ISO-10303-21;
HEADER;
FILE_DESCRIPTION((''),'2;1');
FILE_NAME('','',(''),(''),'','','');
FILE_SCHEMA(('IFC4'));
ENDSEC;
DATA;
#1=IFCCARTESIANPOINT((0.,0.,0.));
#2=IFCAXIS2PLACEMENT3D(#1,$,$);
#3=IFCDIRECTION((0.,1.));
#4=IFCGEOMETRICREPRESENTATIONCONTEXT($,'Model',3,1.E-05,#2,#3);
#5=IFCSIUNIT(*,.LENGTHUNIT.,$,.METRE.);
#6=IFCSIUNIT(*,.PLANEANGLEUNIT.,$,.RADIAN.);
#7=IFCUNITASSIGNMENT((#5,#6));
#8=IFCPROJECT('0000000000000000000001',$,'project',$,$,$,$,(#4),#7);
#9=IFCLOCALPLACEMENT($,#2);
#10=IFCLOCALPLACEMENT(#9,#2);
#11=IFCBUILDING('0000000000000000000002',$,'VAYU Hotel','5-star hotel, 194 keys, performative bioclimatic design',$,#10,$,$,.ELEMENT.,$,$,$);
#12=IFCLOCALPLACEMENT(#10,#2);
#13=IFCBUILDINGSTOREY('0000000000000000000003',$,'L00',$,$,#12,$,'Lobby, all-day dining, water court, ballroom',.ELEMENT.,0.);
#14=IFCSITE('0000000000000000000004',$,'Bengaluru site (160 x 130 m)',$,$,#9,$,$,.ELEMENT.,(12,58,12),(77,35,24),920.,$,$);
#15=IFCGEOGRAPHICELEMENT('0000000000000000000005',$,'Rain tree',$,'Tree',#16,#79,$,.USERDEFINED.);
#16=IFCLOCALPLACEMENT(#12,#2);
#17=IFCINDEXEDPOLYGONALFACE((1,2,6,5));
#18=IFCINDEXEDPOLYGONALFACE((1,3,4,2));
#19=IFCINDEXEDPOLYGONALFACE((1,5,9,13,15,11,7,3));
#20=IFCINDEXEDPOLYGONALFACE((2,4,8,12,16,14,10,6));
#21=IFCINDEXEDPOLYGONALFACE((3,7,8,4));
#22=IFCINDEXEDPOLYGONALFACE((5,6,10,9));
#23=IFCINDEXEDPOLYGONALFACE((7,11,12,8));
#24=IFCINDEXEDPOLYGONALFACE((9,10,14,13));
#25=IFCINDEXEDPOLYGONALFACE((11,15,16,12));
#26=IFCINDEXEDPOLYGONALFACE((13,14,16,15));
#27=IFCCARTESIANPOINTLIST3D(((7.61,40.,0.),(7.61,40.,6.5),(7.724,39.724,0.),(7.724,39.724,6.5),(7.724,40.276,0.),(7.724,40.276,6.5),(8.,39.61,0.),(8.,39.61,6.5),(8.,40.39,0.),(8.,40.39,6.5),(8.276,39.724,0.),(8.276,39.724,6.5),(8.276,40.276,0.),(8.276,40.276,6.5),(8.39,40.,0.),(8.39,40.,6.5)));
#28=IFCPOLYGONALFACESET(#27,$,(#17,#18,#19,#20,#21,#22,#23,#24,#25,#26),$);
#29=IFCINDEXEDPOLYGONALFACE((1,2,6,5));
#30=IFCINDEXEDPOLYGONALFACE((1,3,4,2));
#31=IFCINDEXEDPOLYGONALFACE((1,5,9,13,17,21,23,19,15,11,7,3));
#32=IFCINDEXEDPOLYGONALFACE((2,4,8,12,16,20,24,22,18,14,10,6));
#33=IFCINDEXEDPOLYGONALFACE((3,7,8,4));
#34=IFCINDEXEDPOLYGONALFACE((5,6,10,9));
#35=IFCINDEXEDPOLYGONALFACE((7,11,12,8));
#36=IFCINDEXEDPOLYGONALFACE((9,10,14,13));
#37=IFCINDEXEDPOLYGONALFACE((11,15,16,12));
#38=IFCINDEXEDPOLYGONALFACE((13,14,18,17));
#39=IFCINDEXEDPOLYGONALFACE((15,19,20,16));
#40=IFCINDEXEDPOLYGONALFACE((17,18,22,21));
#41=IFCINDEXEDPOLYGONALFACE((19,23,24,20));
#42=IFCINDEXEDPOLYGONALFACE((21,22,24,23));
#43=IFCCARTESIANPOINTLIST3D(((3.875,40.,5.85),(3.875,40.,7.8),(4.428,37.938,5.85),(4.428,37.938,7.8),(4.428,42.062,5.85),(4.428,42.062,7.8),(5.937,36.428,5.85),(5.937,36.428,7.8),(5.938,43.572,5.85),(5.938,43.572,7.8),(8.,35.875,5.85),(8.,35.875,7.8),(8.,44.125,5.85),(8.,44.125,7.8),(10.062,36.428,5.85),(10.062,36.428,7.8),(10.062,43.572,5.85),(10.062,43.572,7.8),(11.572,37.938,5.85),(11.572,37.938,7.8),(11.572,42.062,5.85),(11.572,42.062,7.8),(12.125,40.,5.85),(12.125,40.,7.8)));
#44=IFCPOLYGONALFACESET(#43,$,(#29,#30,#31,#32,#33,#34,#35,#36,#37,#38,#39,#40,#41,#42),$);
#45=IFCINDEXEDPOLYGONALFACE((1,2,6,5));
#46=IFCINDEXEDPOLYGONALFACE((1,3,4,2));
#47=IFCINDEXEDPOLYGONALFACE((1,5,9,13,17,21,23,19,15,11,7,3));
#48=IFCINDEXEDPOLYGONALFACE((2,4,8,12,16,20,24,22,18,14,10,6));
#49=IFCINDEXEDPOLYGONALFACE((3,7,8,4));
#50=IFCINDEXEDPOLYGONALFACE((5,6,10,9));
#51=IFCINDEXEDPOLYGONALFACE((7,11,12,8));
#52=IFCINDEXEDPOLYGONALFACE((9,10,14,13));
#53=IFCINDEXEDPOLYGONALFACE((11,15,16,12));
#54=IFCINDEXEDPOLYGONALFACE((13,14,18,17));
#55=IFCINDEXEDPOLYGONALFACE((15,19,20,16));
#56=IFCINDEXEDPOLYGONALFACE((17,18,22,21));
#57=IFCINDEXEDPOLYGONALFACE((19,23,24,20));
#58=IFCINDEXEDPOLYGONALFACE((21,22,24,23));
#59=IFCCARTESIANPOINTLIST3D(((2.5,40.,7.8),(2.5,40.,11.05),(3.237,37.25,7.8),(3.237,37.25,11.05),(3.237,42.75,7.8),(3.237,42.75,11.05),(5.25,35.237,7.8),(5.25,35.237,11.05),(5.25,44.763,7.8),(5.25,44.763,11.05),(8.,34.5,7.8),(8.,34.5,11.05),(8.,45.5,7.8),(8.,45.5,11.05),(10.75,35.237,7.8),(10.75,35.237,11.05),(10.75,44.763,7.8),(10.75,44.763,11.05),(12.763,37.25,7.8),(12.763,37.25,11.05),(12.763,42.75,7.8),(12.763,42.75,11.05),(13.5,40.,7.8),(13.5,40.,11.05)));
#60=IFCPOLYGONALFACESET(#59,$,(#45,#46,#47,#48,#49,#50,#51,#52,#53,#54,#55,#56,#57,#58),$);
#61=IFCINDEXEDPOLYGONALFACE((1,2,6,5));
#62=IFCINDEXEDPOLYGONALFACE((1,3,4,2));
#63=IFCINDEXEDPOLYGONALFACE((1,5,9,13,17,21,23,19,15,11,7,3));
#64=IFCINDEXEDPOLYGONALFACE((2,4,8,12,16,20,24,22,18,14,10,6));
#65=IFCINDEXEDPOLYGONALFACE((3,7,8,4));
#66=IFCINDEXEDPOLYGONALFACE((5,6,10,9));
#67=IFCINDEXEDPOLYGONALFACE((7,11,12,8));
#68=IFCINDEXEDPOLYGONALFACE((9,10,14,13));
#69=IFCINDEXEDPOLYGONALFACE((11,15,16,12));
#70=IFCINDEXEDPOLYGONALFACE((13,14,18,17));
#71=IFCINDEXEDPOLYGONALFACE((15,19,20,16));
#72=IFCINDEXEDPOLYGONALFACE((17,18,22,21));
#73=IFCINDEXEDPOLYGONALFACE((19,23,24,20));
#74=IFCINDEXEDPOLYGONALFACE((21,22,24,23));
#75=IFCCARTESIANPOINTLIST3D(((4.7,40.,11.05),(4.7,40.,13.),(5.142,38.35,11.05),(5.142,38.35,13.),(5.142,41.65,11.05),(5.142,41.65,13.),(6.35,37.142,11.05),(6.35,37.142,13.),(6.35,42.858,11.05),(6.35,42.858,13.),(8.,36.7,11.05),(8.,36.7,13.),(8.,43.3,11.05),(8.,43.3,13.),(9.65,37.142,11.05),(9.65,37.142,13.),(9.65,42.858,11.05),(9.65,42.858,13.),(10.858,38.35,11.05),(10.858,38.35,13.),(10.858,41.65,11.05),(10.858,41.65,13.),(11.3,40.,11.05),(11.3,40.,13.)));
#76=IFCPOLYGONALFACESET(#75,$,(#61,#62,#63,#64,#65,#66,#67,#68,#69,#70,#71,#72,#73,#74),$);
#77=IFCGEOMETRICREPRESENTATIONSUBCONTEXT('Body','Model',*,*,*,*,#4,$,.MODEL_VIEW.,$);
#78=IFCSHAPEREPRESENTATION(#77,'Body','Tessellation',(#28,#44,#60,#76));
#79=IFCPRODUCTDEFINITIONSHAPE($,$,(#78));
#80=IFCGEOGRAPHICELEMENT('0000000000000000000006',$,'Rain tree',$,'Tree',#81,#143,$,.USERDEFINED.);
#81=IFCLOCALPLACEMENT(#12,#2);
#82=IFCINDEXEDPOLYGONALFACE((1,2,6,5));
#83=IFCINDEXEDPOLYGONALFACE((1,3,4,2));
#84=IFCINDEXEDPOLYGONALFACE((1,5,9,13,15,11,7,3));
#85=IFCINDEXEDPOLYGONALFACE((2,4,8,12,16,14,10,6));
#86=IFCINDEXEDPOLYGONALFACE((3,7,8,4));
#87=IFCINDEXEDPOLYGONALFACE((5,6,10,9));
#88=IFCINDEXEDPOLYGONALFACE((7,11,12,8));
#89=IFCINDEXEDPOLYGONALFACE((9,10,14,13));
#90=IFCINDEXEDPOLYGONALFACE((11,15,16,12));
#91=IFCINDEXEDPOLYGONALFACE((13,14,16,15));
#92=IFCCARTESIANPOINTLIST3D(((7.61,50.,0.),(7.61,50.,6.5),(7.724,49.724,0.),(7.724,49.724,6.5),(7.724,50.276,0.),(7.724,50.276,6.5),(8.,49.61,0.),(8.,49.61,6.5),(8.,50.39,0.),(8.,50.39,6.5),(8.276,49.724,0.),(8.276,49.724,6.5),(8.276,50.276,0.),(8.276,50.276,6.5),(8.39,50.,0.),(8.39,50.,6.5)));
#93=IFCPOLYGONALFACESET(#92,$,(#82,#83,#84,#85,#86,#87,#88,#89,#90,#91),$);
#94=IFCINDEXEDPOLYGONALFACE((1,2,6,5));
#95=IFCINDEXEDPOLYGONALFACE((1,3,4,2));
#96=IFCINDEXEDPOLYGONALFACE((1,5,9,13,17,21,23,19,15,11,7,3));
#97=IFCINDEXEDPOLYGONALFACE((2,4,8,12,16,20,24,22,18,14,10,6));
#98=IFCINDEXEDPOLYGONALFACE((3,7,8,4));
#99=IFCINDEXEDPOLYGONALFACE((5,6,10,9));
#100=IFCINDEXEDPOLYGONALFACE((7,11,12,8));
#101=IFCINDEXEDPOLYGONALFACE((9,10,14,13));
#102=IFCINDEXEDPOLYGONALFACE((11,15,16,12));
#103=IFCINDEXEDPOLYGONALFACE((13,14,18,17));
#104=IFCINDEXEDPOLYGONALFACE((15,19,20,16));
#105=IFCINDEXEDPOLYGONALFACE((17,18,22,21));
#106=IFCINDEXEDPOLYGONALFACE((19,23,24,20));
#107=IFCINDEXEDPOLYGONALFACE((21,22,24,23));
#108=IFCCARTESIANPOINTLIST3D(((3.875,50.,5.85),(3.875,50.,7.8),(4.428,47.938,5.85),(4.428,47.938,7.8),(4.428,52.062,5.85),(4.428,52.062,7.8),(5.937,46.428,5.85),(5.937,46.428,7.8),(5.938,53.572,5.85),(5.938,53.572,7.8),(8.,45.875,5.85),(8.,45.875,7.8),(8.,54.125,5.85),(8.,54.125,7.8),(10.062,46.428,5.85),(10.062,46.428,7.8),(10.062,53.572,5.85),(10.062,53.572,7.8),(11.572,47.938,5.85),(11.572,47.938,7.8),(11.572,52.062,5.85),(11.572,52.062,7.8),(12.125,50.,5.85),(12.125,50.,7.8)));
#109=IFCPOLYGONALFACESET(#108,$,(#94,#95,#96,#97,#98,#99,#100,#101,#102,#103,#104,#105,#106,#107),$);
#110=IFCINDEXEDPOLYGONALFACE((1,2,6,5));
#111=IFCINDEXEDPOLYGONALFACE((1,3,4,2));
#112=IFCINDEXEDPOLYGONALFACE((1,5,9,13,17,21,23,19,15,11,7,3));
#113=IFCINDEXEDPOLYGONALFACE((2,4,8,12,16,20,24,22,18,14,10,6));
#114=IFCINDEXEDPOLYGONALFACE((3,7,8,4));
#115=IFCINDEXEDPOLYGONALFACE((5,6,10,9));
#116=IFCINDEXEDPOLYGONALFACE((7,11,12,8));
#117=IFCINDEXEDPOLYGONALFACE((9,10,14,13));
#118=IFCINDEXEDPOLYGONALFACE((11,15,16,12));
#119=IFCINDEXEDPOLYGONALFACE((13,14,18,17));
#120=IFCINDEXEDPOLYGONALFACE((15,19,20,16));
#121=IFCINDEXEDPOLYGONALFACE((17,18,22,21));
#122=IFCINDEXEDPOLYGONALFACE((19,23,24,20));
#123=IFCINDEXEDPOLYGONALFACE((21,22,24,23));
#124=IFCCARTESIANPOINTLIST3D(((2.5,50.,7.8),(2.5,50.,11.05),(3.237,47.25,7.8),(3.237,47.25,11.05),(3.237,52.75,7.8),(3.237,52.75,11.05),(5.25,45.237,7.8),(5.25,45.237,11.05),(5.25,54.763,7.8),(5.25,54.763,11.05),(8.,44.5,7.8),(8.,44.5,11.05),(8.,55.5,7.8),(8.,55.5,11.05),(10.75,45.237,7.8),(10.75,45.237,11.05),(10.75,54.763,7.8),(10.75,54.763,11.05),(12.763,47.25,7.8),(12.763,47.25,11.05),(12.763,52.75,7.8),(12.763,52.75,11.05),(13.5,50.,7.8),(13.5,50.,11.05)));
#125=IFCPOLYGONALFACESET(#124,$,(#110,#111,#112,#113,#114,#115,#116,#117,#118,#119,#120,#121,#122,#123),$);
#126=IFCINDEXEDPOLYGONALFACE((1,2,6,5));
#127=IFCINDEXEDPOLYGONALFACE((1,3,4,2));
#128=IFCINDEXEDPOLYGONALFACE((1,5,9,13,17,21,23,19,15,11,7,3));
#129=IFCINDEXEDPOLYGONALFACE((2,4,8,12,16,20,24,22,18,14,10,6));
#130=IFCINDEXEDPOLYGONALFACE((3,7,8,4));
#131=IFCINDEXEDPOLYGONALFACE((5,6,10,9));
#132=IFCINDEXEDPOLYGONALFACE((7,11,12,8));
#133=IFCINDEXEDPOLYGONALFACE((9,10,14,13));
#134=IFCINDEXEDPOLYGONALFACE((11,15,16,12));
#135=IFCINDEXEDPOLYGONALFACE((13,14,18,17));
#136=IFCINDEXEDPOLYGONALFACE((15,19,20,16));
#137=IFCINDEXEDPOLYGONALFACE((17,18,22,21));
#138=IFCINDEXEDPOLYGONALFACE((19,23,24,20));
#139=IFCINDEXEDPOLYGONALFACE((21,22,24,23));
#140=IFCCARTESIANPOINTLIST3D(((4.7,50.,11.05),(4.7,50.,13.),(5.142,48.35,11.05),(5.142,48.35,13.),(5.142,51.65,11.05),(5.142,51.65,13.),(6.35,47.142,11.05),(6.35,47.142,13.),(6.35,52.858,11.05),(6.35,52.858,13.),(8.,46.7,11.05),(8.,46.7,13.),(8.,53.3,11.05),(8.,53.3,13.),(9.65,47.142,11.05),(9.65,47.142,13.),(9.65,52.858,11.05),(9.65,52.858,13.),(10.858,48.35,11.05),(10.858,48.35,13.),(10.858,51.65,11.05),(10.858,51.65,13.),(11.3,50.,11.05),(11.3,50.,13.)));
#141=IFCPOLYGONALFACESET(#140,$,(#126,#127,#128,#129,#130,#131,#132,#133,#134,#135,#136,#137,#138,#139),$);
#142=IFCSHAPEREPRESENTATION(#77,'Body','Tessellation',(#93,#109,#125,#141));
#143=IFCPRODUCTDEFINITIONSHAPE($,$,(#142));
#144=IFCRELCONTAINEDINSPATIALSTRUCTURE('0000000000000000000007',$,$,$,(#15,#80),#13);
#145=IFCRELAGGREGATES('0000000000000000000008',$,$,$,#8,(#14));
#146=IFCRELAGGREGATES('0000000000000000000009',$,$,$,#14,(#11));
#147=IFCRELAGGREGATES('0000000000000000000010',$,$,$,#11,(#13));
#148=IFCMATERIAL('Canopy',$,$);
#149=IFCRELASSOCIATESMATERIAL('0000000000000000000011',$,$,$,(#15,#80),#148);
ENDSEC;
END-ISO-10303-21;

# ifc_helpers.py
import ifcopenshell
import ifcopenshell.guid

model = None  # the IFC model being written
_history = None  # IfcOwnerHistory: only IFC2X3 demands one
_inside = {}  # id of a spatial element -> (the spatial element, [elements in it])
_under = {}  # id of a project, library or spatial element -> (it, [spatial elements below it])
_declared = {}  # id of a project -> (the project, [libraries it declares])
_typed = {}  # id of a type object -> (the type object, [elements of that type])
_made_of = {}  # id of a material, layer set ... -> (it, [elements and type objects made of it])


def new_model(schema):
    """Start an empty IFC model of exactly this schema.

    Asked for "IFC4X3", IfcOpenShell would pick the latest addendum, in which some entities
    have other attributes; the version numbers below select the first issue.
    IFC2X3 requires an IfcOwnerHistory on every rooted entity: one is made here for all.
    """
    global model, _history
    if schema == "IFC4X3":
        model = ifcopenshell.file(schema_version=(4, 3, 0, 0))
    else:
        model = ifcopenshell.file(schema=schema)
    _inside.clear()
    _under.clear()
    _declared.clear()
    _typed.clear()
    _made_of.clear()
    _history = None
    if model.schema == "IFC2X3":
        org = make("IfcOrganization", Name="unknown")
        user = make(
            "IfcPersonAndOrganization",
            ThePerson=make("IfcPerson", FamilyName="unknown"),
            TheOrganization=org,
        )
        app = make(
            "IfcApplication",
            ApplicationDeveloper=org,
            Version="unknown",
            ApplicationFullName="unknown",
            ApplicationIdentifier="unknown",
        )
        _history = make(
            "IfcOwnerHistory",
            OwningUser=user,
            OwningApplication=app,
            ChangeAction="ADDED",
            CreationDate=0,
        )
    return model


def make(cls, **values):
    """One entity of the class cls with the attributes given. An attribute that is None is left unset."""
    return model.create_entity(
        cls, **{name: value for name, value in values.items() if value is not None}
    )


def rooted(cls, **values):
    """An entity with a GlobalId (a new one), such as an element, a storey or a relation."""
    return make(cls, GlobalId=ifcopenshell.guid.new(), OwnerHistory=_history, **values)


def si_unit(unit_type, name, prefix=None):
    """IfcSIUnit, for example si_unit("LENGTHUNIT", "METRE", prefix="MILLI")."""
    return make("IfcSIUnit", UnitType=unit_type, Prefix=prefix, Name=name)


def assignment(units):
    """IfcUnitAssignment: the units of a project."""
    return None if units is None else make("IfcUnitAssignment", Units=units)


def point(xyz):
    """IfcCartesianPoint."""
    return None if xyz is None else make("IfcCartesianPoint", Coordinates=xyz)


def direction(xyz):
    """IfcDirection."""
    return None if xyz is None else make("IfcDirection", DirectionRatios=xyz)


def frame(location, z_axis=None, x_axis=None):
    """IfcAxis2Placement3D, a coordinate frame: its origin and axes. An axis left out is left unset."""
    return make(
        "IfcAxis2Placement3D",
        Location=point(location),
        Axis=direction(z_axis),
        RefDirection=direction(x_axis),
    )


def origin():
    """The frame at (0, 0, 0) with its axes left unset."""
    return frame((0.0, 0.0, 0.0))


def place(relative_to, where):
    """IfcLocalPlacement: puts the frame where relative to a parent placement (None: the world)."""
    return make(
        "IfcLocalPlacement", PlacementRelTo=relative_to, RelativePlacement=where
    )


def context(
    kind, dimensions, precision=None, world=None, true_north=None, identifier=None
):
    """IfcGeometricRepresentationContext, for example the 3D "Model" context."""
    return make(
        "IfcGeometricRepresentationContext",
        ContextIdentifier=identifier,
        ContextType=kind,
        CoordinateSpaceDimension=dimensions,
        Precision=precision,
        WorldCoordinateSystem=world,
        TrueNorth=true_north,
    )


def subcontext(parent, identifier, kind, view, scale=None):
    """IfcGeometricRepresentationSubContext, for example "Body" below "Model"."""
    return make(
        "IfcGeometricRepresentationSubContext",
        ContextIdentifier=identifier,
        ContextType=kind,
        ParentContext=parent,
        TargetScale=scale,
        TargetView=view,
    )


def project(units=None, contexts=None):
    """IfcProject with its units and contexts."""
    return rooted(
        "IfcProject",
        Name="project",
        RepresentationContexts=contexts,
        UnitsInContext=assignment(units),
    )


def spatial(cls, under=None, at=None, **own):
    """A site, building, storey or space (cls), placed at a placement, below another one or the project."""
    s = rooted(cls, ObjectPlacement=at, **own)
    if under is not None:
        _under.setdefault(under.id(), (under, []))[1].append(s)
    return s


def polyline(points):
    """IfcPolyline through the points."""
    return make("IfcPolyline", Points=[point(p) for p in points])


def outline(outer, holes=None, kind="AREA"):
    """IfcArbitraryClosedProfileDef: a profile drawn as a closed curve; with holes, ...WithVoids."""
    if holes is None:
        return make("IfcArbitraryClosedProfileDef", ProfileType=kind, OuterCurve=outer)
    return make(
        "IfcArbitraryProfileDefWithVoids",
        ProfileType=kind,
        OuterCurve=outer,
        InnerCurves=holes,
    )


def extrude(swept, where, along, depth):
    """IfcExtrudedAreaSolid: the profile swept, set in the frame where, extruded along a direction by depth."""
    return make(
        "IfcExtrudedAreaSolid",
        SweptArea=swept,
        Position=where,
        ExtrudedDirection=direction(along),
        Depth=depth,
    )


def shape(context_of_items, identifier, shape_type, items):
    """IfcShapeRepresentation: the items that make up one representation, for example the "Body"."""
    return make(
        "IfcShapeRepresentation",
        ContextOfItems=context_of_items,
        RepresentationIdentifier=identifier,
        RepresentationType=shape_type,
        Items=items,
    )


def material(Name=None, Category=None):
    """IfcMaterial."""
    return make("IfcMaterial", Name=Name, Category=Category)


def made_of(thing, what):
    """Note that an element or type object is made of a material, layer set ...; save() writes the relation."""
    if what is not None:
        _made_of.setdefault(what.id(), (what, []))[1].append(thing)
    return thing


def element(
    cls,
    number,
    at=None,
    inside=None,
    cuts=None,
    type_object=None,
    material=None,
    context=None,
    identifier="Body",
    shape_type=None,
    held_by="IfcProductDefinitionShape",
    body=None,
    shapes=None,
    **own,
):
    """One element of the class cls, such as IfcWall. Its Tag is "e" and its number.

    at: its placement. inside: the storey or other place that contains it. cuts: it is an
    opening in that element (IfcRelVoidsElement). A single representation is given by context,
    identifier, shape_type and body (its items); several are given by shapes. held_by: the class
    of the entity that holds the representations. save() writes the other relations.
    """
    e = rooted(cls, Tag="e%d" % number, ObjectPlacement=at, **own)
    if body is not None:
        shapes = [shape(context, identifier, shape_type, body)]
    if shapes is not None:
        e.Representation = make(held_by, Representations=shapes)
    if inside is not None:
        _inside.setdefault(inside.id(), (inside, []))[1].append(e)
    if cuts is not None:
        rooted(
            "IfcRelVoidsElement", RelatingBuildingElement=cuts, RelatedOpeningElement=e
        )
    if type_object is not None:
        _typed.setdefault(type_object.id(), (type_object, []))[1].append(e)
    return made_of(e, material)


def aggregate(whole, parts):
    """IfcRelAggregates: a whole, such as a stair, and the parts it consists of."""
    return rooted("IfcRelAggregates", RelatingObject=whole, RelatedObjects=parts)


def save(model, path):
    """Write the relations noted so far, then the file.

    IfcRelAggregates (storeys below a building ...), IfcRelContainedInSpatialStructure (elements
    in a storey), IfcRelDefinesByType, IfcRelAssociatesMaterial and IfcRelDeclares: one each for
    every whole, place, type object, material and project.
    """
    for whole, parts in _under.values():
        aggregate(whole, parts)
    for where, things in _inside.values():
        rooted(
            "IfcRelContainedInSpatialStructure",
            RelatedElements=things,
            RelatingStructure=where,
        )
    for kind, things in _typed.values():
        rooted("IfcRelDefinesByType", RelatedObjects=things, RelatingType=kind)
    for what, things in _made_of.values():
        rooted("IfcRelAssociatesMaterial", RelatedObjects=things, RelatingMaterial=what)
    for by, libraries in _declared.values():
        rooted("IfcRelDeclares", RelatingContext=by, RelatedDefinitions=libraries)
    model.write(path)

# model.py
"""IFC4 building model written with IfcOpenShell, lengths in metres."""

from ifc_helpers import new_model, si_unit, direction, frame, origin, place, context, subcontext, project, spatial, polyline, outline, extrude, material, element, save


model = new_model("IFC4")

# Units and contexts
model_context = context("Model", 3, precision=1e-05, world=origin(), true_north=direction((0.0, 1.0)))
body_context = subcontext(model_context, "Body", "Model", "MODEL_VIEW")
ifc_project = project(units=[si_unit("LENGTHUNIT", "METRE"), si_unit("PLANEANGLEUNIT", "RADIAN")], contexts=[model_context])

# Site, building, storey
site_placement = place(None, origin())
site = spatial("IfcSite", under=ifc_project, at=site_placement, Name="Bengaluru site (160 x 130 m)", CompositionType="ELEMENT", RefLatitude=(12, 58, 12), RefLongitude=(77, 35, 24), RefElevation=920.0)
building_placement = place(site_placement, origin())
building = spatial("IfcBuilding", under=site, at=building_placement, Name="VAYU Hotel", Description="5-star hotel, 194 keys, performative bioclimatic design", CompositionType="ELEMENT")
storey_placement = place(building_placement, origin())
storey = spatial("IfcBuildingStorey", under=building, at=storey_placement, Name="L00", LongName="Lobby, all-day dining, water court, ballroom", CompositionType="ELEMENT", Elevation=0.0)

# Geographic elements
ifc_material_1 = material(Name="Canopy")
geographic_element_1_placement = place(storey_placement, origin())
element("IfcGeographicElement", 1, at=geographic_element_1_placement, inside=storey, material=ifc_material_1, Name="Rain tree", ObjectType="Tree", PredefinedType="USERDEFINED", context=body_context, shape_type="SweptSolid", body=[
    extrude(outline(polyline([(8.39, 40.0), (8.276, 40.276), (8.0, 40.39), (7.724, 40.276), (7.61, 40.0), (7.724, 39.724), (8.0, 39.61), (8.276, 39.724), (8.39, 40.0)])), origin(), (0.0, 0.0, 1.0), 6.5),
    extrude(outline(polyline([(12.125, 40.0), (11.572, 42.062), (10.062, 43.572), (8.0, 44.125), (5.938, 43.572), (4.428, 42.062), (3.875, 40.0), (4.428, 37.938), (5.937, 36.428), (8.0, 35.875), (10.062, 36.428), (11.572, 37.938), (12.125, 40.0)])), frame((0.0, 0.0, 5.85)), (0.0, 0.0, 1.0), 1.95),
    extrude(outline(polyline([(13.5, 40.0), (12.763, 42.75), (10.75, 44.763), (8.0, 45.5), (5.25, 44.763), (3.237, 42.75), (2.5, 40.0), (3.237, 37.25), (5.25, 35.237), (8.0, 34.5), (10.75, 35.237), (12.763, 37.25), (13.5, 40.0)])), frame((0.0, 0.0, 7.8)), (0.0, 0.0, 1.0), 3.25),
    extrude(outline(polyline([(11.3, 40.0), (10.858, 41.65), (9.65, 42.858), (8.0, 43.3), (6.35, 42.858), (5.142, 41.65), (4.7, 40.0), (5.142, 38.35), (6.35, 37.142), (8.0, 36.7), (9.65, 37.142), (10.858, 38.35), (11.3, 40.0)])), frame((0.0, 0.0, 11.05)), (0.0, 0.0, 1.0), 1.95),
])
geographic_element_2_placement = place(storey_placement, origin())
element("IfcGeographicElement", 2, at=geographic_element_2_placement, inside=storey, material=ifc_material_1, Name="Rain tree", ObjectType="Tree", PredefinedType="USERDEFINED", context=body_context, shape_type="SweptSolid", body=[
    extrude(outline(polyline([(8.39, 50.0), (8.276, 50.276), (8.0, 50.39), (7.724, 50.276), (7.61, 50.0), (7.724, 49.724), (8.0, 49.61), (8.276, 49.724), (8.39, 50.0)])), origin(), (0.0, 0.0, 1.0), 6.5),
    extrude(outline(polyline([(12.125, 50.0), (11.572, 52.062), (10.062, 53.572), (8.0, 54.125), (5.938, 53.572), (4.428, 52.062), (3.875, 50.0), (4.428, 47.938), (5.937, 46.428), (8.0, 45.875), (10.062, 46.428), (11.572, 47.938), (12.125, 50.0)])), frame((0.0, 0.0, 5.85)), (0.0, 0.0, 1.0), 1.95),
    extrude(outline(polyline([(13.5, 50.0), (12.763, 52.75), (10.75, 54.763), (8.0, 55.5), (5.25, 54.763), (3.237, 52.75), (2.5, 50.0), (3.237, 47.25), (5.25, 45.237), (8.0, 44.5), (10.75, 45.237), (12.763, 47.25), (13.5, 50.0)])), frame((0.0, 0.0, 7.8)), (0.0, 0.0, 1.0), 3.25),
    extrude(outline(polyline([(11.3, 50.0), (10.858, 51.65), (9.65, 52.858), (8.0, 53.3), (6.35, 52.858), (5.142, 51.65), (4.7, 50.0), (5.142, 48.35), (6.35, 47.142), (8.0, 46.7), (9.65, 47.142), (10.858, 48.35), (11.3, 50.0)])), frame((0.0, 0.0, 11.05)), (0.0, 0.0, 1.0), 1.95),
])

save(model, "model.ifc")
